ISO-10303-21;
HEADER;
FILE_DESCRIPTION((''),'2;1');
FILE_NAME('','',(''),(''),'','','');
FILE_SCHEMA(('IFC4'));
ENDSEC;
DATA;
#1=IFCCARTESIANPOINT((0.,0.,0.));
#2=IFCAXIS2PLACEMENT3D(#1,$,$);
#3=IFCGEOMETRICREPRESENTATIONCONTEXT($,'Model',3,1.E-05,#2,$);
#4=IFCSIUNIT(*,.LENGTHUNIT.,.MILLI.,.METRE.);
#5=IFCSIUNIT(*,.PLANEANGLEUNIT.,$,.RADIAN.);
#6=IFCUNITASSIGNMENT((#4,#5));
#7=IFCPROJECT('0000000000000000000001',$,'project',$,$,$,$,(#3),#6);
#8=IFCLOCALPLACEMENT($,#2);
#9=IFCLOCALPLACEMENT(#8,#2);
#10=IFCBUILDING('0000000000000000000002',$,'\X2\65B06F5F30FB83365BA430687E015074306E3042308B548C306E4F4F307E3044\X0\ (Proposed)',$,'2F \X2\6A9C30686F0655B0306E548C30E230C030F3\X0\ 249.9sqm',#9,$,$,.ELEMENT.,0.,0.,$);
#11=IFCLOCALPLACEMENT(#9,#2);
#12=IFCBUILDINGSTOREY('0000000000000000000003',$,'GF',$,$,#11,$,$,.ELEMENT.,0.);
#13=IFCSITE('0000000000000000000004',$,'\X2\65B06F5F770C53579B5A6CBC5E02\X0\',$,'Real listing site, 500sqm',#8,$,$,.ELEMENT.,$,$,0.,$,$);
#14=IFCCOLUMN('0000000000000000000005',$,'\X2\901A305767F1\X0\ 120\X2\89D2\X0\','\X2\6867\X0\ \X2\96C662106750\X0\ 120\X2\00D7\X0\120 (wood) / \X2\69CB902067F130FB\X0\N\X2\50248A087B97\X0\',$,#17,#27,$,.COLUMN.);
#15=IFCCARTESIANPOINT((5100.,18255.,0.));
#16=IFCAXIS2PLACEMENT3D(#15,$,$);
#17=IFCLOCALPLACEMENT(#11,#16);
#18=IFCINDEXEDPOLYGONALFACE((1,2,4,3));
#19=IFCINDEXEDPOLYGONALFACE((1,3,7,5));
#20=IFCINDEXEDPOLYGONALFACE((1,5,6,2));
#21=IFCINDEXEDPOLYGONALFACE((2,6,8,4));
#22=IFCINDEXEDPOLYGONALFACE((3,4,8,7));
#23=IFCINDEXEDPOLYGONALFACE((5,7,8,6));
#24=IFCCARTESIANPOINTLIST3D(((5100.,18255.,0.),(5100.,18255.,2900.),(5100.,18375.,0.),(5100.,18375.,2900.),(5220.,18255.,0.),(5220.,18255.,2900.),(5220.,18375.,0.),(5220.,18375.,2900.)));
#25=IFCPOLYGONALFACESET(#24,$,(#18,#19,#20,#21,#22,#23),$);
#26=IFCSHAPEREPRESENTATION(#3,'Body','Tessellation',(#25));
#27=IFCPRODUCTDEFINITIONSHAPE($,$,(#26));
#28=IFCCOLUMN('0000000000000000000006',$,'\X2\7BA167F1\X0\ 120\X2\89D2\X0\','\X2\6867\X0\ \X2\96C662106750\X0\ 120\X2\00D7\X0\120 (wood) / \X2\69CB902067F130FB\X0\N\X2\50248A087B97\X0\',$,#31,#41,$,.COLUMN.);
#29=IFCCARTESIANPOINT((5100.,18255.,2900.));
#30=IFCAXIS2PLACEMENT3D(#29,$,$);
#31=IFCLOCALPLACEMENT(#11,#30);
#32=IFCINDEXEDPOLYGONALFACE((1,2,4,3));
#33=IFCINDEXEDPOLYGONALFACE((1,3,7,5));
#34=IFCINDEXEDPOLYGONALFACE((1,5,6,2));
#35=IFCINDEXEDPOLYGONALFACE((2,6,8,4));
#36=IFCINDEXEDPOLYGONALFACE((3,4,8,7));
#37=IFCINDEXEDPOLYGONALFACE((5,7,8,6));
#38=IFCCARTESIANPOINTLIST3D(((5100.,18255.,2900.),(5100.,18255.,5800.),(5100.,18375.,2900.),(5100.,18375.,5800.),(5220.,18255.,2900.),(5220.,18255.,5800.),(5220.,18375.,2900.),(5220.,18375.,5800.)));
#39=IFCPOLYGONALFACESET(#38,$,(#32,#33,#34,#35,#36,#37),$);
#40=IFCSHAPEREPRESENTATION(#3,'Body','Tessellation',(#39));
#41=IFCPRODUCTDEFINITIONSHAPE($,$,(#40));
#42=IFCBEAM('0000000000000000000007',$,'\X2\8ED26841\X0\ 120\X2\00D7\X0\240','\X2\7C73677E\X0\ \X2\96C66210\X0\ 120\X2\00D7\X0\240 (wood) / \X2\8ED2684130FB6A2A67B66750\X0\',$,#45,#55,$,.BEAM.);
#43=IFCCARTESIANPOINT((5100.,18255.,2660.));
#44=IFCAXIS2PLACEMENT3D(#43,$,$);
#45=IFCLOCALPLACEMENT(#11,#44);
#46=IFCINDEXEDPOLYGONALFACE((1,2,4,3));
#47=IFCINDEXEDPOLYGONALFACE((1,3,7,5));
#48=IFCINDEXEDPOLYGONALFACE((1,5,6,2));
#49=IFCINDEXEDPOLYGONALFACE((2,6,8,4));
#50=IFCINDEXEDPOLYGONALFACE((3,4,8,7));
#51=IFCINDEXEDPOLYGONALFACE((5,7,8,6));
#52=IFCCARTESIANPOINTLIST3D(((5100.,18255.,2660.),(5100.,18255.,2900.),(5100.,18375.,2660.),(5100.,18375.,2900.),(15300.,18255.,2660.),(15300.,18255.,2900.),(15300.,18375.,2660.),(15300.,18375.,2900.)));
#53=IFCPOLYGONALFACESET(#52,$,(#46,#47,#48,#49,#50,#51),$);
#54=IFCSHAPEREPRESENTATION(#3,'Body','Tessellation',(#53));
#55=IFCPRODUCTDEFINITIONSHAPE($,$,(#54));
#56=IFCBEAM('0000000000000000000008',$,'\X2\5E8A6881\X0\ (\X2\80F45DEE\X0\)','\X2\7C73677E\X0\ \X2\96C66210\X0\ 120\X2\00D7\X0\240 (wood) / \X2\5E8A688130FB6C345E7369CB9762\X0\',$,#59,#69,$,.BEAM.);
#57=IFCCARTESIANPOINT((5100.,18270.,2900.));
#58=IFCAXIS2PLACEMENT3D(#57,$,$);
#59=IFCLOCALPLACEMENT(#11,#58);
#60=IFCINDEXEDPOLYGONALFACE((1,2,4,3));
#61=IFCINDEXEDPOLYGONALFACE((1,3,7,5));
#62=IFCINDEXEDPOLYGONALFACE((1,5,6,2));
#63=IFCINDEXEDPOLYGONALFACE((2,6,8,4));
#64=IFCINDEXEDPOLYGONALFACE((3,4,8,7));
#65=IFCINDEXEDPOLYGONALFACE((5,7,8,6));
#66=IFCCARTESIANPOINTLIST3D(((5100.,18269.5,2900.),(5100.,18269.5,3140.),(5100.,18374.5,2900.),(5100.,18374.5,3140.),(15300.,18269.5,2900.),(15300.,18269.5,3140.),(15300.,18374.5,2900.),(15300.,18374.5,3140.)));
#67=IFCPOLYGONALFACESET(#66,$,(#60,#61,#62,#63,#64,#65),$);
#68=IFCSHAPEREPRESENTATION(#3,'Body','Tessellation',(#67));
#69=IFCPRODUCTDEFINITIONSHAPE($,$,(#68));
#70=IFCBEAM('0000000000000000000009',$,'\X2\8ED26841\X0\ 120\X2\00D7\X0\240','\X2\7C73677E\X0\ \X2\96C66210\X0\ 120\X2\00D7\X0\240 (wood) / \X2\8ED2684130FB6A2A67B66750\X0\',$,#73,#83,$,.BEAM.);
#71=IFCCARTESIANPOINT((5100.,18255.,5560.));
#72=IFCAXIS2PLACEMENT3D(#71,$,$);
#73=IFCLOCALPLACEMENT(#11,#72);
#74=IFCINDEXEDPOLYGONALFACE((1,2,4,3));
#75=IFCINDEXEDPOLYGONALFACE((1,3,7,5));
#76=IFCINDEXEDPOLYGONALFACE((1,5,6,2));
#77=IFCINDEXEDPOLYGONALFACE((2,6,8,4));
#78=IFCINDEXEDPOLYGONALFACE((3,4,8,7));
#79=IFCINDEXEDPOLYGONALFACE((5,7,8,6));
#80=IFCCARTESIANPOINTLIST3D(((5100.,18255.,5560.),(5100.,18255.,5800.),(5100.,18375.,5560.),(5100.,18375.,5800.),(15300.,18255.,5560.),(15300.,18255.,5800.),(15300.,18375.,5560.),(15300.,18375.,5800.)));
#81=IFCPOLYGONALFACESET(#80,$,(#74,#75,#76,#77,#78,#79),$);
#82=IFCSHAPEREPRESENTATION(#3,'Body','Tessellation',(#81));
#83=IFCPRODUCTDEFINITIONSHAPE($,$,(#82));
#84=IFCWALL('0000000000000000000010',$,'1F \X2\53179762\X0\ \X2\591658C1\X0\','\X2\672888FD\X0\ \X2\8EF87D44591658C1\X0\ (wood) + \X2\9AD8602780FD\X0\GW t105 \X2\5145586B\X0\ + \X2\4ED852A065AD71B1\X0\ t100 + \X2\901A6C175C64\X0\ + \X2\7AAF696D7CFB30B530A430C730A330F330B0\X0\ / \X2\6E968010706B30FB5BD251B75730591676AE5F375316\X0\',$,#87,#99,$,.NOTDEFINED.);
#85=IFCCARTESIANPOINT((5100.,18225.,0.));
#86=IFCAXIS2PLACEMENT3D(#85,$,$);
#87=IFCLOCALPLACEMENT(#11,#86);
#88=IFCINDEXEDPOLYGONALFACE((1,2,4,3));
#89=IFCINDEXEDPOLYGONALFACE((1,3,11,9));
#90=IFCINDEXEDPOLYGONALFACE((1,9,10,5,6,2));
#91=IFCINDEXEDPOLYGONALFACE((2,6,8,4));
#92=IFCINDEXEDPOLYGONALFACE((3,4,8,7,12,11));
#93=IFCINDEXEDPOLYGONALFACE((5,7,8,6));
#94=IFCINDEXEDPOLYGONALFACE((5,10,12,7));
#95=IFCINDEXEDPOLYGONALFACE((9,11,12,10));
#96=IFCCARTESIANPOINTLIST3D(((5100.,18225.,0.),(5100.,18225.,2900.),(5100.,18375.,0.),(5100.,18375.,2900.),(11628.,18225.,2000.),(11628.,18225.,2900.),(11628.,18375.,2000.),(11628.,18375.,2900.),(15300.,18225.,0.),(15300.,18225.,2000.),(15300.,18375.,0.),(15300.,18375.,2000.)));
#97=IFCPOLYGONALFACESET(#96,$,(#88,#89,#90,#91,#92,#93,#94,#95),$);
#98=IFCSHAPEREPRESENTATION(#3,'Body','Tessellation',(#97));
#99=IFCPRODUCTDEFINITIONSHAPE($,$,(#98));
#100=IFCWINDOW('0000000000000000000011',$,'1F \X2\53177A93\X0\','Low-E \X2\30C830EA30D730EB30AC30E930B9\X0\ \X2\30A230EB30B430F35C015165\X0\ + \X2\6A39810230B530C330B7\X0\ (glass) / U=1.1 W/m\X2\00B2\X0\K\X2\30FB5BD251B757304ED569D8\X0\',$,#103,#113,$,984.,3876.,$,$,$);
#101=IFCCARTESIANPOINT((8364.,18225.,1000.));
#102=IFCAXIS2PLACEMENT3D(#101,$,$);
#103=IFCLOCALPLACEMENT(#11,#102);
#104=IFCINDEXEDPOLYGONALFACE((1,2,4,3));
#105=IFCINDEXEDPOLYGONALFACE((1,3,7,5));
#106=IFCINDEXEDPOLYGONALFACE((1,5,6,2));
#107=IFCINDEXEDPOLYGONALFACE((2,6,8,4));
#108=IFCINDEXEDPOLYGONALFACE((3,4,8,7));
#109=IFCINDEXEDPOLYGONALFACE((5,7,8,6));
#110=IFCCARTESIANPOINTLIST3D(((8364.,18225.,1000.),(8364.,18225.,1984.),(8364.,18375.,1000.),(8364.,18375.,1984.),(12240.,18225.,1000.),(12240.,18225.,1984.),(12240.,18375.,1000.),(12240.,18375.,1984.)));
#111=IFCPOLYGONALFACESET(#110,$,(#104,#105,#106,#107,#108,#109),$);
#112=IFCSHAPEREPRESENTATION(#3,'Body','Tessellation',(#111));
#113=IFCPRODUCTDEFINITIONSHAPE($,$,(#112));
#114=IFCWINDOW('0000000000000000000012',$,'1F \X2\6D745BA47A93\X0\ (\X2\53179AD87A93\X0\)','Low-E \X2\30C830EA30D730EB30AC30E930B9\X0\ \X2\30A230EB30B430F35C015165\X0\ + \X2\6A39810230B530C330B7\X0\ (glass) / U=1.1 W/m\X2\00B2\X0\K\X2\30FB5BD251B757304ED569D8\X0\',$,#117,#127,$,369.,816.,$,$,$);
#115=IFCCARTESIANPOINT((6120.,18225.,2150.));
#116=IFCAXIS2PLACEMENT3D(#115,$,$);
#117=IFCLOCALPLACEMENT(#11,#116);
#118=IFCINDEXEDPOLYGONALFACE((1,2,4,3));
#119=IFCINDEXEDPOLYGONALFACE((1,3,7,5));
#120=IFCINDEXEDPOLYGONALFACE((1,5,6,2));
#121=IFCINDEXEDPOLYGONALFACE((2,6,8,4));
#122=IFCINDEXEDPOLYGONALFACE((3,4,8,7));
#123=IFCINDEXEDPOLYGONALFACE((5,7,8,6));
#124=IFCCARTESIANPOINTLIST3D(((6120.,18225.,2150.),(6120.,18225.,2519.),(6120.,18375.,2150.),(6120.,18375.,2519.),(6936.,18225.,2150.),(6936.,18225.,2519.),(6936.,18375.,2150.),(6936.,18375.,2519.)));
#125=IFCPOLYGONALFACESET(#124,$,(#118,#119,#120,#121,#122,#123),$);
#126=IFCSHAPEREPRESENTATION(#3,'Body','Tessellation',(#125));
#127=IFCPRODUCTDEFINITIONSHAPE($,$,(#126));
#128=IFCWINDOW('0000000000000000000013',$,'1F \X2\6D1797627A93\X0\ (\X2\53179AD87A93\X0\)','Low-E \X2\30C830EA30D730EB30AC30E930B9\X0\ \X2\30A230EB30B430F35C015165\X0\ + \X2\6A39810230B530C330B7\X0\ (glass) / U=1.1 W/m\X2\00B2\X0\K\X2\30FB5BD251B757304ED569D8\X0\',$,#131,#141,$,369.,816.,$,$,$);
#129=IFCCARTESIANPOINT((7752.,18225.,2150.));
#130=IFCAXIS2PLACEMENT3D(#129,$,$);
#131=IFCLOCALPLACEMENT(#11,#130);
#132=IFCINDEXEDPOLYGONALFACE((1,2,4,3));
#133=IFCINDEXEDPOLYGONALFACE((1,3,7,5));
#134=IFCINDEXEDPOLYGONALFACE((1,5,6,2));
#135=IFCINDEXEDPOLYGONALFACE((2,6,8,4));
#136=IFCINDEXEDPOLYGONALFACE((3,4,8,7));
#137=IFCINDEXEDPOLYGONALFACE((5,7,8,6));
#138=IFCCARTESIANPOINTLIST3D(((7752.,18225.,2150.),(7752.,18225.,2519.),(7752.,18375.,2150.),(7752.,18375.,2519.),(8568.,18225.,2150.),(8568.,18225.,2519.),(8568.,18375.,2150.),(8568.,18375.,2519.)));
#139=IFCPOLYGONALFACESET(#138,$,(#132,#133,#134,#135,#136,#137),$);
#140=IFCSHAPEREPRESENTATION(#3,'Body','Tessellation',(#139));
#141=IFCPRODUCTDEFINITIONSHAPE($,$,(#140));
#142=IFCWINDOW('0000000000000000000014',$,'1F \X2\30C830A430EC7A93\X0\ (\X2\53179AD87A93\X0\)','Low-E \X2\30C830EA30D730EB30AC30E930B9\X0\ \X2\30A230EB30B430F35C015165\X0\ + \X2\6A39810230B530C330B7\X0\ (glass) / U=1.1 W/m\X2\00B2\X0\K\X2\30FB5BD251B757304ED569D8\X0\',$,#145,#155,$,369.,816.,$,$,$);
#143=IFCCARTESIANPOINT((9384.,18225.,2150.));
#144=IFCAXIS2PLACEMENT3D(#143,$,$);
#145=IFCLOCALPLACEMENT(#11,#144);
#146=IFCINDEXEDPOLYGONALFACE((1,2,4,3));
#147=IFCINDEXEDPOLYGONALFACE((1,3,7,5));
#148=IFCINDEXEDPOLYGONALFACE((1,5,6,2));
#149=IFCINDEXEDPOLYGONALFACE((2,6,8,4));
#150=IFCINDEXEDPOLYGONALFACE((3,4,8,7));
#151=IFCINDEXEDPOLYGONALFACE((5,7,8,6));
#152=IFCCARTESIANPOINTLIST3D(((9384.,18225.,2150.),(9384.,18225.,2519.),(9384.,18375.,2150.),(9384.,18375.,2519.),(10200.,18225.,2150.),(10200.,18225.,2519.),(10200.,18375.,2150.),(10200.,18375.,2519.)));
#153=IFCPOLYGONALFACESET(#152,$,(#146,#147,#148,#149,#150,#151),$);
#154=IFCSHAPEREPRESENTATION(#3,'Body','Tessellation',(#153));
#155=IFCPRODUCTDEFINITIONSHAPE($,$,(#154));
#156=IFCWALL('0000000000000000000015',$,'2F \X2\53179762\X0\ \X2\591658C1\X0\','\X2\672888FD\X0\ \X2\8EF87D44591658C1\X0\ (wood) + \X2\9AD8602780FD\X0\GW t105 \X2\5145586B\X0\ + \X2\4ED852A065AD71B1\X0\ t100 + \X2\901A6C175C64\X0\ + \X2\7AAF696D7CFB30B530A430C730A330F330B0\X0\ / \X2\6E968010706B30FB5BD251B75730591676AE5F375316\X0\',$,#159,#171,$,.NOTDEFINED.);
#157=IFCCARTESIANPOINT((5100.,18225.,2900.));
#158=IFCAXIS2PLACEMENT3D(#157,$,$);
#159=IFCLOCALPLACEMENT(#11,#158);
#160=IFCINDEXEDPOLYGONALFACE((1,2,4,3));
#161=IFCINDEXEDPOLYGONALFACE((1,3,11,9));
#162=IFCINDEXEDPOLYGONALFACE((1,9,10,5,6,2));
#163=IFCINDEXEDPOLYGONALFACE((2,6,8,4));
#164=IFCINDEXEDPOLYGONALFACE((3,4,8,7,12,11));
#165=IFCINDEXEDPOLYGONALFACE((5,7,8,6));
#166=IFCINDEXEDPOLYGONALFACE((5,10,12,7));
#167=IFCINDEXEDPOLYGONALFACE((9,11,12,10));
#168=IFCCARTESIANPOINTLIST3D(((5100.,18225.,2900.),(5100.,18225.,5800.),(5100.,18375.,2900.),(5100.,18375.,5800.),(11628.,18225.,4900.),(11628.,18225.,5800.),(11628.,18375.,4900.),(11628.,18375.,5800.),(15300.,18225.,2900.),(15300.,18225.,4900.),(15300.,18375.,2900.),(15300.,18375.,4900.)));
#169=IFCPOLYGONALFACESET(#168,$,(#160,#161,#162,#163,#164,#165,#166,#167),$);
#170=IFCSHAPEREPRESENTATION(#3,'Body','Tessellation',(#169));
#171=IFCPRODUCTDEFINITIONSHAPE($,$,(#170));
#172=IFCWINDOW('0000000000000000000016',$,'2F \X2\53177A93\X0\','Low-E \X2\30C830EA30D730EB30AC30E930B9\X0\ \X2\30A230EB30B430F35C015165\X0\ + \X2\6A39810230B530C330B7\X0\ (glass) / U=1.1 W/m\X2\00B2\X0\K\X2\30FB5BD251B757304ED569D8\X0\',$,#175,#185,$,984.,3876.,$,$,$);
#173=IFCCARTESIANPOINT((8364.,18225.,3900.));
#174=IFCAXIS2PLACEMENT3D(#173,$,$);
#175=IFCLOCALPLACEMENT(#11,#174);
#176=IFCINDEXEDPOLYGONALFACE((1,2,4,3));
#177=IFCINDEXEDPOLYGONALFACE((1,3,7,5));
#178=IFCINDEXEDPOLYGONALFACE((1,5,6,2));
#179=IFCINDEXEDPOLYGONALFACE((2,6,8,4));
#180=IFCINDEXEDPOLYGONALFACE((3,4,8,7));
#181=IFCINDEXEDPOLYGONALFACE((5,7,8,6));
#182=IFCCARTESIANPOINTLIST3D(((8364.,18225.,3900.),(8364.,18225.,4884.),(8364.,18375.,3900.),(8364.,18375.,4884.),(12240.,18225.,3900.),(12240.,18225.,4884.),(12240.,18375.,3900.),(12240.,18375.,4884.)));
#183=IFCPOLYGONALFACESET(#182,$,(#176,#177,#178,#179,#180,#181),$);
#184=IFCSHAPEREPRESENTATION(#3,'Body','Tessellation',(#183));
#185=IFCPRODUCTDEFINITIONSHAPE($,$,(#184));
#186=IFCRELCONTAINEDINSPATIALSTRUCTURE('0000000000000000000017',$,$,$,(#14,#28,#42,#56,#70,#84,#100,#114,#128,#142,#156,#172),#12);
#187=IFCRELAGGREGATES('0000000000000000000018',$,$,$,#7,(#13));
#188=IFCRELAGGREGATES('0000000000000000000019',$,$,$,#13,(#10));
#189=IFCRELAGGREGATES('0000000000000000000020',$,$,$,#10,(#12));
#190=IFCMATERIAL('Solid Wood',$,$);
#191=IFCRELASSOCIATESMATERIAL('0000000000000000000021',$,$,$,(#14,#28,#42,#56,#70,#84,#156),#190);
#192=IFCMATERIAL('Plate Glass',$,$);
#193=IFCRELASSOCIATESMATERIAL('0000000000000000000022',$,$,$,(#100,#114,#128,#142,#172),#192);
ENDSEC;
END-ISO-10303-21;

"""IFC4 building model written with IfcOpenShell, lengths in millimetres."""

from ifc_helpers import new_model, si_unit, frame, frame_2d, origin, place, context, project, spatial, rectangle, extrude, material, element, fill, save


model = new_model("IFC4")

# Units and contexts
model_context = context("Model", 3, precision=1e-05, world=origin())
ifc_project = project(units=[si_unit("LENGTHUNIT", "METRE", prefix="MILLI"), si_unit("PLANEANGLEUNIT", "RADIAN")], contexts=[model_context])

# Site, building, storey
site_placement = place(None, origin())
site = spatial("IfcSite", under=ifc_project, at=site_placement, Name="新潟県南魚沼市", ObjectType="Real listing site, 500sqm", CompositionType="ELEMENT", RefElevation=0.0)
building_placement = place(site_placement, origin())
building = spatial("IfcBuilding", under=site, at=building_placement, Name="新潟・茶室と縁側のある和の住まい (Proposed)", ObjectType="2F 檜と漆喰の和モダン 249.9sqm", CompositionType="ELEMENT", ElevationOfRefHeight=0.0, ElevationOfTerrain=0.0)
storey_placement = place(building_placement, origin())
storey = spatial("IfcBuildingStorey", under=building, at=storey_placement, Name="GF", CompositionType="ELEMENT", Elevation=0.0)

# Columns
ifc_material_1 = material(Name="Solid Wood")
column_1_placement = place(storey_placement, frame((5100.0, 18255.0, 0.0)))
element("IfcColumn", 1, at=column_1_placement, inside=storey, material=ifc_material_1, Name="通し柱 120角", Description="桧 集成材 120×120 (wood) / 構造柱・N値計算", PredefinedType="COLUMN", context=model_context, shape_type="SweptSolid", body=[
    extrude(rectangle(XDim=120.0, YDim=120.0, at=frame_2d((60.0, 60.0))), frame((5100.0, 18255.0, 0.0)), (0.0, 0.0, 1.0), 2900.0),
])
column_2_placement = place(storey_placement, frame((5100.0, 18255.0, 2900.0)))
element("IfcColumn", 2, at=column_2_placement, inside=storey, material=ifc_material_1, Name="管柱 120角", Description="桧 集成材 120×120 (wood) / 構造柱・N値計算", PredefinedType="COLUMN", context=model_context, shape_type="SweptSolid", body=[
    extrude(rectangle(XDim=120.0, YDim=120.0, at=frame_2d((60.0, 60.0))), frame((5100.0, 18255.0, 2900.0)), (0.0, 0.0, 1.0), 2900.0),
])

# Beams
beam_1_placement = place(storey_placement, frame((5100.0, 18255.0, 2660.0)))
element("IfcBeam", 3, at=beam_1_placement, inside=storey, material=ifc_material_1, Name="軒桁 120×240", Description="米松 集成 120×240 (wood) / 軒桁・横架材", PredefinedType="BEAM", context=model_context, shape_type="SweptSolid", body=[
    extrude(rectangle(XDim=10200.0, YDim=120.0, at=frame_2d((5100.0, 60.0))), frame((5100.0, 18255.0, 2660.0)), (0.0, 0.0, 1.0), 240.0),
])
beam_2_placement = place(storey_placement, frame((5100.0, 18270.0, 2900.0)))
element("IfcBeam", 4, at=beam_2_placement, inside=storey, material=ifc_material_1, Name="床梁 (胴差)", Description="米松 集成 120×240 (wood) / 床梁・水平構面", PredefinedType="BEAM", context=model_context, shape_type="SweptSolid", body=[
    extrude(rectangle(XDim=10200.0, YDim=105.0, at=frame_2d((5100.0, 52.0))), frame((5100.0, 18270.0, 2900.0)), (0.0, 0.0, 1.0), 240.0),
])
beam_3_placement = place(storey_placement, frame((5100.0, 18255.0, 5560.0)))
element("IfcBeam", 5, at=beam_3_placement, inside=storey, material=ifc_material_1, Name="軒桁 120×240", Description="米松 集成 120×240 (wood) / 軒桁・横架材", PredefinedType="BEAM", context=model_context, shape_type="SweptSolid", body=[
    extrude(rectangle(XDim=10200.0, YDim=120.0, at=frame_2d((5100.0, 60.0))), frame((5100.0, 18255.0, 5560.0)), (0.0, 0.0, 1.0), 240.0),
])

# Wall, openings, windows
wall_1_placement = place(storey_placement, frame((5100.0, 18225.0, 0.0)))
wall_1 = element("IfcWall", 6, at=wall_1_placement, inside=storey, material=ifc_material_1, Name="1F 北面 外壁", Description="木製 軸組外壁 (wood) + 高性能GW t105 充填 + 付加断熱 t100 + 通気層 + 窯業系サイディング / 準耐火・寒冷地外皮強化", PredefinedType="NOTDEFINED", context=model_context, shape_type="SweptSolid", body=[
    extrude(rectangle(XDim=10200.0, YDim=150.0, at=frame_2d((5100.0, 75.0))), frame((5100.0, 18225.0, 0.0)), (0.0, 0.0, 1.0), 2900.0),
])
opening_1_placement = place(storey_placement, frame((8364.0, 18225.0, 1000.0)))
opening_1 = element("IfcOpeningElement", 7, at=opening_1_placement, cuts=wall_1, PredefinedType="NOTDEFINED", context=model_context, shape_type="SweptSolid", body=[
    extrude(rectangle(XDim=3876.0, YDim=150.0, at=frame_2d((1938.0, 75.0))), frame((8364.0, 18225.0, 1000.0)), (0.0, 0.0, 1.0), 984.0),
])
opening_2_placement = place(storey_placement, frame((6120.0, 18225.0, 2150.0)))
opening_2 = element("IfcOpeningElement", 8, at=opening_2_placement, cuts=wall_1, PredefinedType="NOTDEFINED", context=model_context, shape_type="SweptSolid", body=[
    extrude(rectangle(XDim=816.0, YDim=150.0, at=frame_2d((408.0, 75.0))), frame((6120.0, 18225.0, 2150.0)), (0.0, 0.0, 1.0), 369.0),
])
opening_3_placement = place(storey_placement, frame((7752.0, 18225.0, 2150.0)))
opening_3 = element("IfcOpeningElement", 9, at=opening_3_placement, cuts=wall_1, PredefinedType="NOTDEFINED", context=model_context, shape_type="SweptSolid", body=[
    extrude(rectangle(XDim=816.0, YDim=150.0, at=frame_2d((408.0, 75.0))), frame((7752.0, 18225.0, 2150.0)), (0.0, 0.0, 1.0), 369.0),
])
opening_4_placement = place(storey_placement, frame((9384.0, 18225.0, 2150.0)))
opening_4 = element("IfcOpeningElement", 10, at=opening_4_placement, cuts=wall_1, PredefinedType="NOTDEFINED", context=model_context, shape_type="SweptSolid", body=[
    extrude(rectangle(XDim=816.0, YDim=150.0, at=frame_2d((408.0, 75.0))), frame((9384.0, 18225.0, 2150.0)), (0.0, 0.0, 1.0), 369.0),
])
ifc_material_2 = material(Name="Plate Glass")
window_1_placement = place(storey_placement, frame((8364.0, 18225.0, 1000.0)))
window_1 = element("IfcWindow", 11, at=window_1_placement, inside=storey, material=ifc_material_2, Name="1F 北窓", Description="Low-E トリプルガラス アルゴン封入 + 樹脂サッシ (glass) / U=1.1 W/m²K・寒冷地仕様", OverallHeight=984.0, OverallWidth=3876.0, context=model_context, shape_type="SweptSolid", body=[
    extrude(rectangle(XDim=3876.0, YDim=150.0, at=frame_2d((1938.0, 75.0))), frame((8364.0, 18225.0, 1000.0)), (0.0, 0.0, 1.0), 984.0),
])
fill(opening_1, window_1)
window_2_placement = place(storey_placement, frame((6120.0, 18225.0, 2150.0)))
window_2 = element("IfcWindow", 12, at=window_2_placement, inside=storey, material=ifc_material_2, Name="1F 浴室窓 (北高窓)", Description="Low-E トリプルガラス アルゴン封入 + 樹脂サッシ (glass) / U=1.1 W/m²K・寒冷地仕様", OverallHeight=369.0, OverallWidth=816.0, context=model_context, shape_type="SweptSolid", body=[
    extrude(rectangle(XDim=816.0, YDim=150.0, at=frame_2d((408.0, 75.0))), frame((6120.0, 18225.0, 2150.0)), (0.0, 0.0, 1.0), 369.0),
])
fill(opening_2, window_2)
window_3_placement = place(storey_placement, frame((7752.0, 18225.0, 2150.0)))
window_3 = element("IfcWindow", 13, at=window_3_placement, inside=storey, material=ifc_material_2, Name="1F 洗面窓 (北高窓)", Description="Low-E トリプルガラス アルゴン封入 + 樹脂サッシ (glass) / U=1.1 W/m²K・寒冷地仕様", OverallHeight=369.0, OverallWidth=816.0, context=model_context, shape_type="SweptSolid", body=[
    extrude(rectangle(XDim=816.0, YDim=150.0, at=frame_2d((408.0, 75.0))), frame((7752.0, 18225.0, 2150.0)), (0.0, 0.0, 1.0), 369.0),
])
fill(opening_3, window_3)
window_4_placement = place(storey_placement, frame((9384.0, 18225.0, 2150.0)))
window_4 = element("IfcWindow", 14, at=window_4_placement, inside=storey, material=ifc_material_2, Name="1F トイレ窓 (北高窓)", Description="Low-E トリプルガラス アルゴン封入 + 樹脂サッシ (glass) / U=1.1 W/m²K・寒冷地仕様", OverallHeight=369.0, OverallWidth=816.0, context=model_context, shape_type="SweptSolid", body=[
    extrude(rectangle(XDim=816.0, YDim=150.0, at=frame_2d((408.0, 75.0))), frame((9384.0, 18225.0, 2150.0)), (0.0, 0.0, 1.0), 369.0),
])
fill(opening_4, window_4)

# Wall, opening, window
wall_2_placement = place(storey_placement, frame((5100.0, 18225.0, 2900.0)))
wall_2 = element("IfcWall", 15, at=wall_2_placement, inside=storey, material=ifc_material_1, Name="2F 北面 外壁", Description="木製 軸組外壁 (wood) + 高性能GW t105 充填 + 付加断熱 t100 + 通気層 + 窯業系サイディング / 準耐火・寒冷地外皮強化", PredefinedType="NOTDEFINED", context=model_context, shape_type="SweptSolid", body=[
    extrude(rectangle(XDim=10200.0, YDim=150.0, at=frame_2d((5100.0, 75.0))), frame((5100.0, 18225.0, 2900.0)), (0.0, 0.0, 1.0), 2900.0),
])
opening_5_placement = place(storey_placement, frame((8364.0, 18225.0, 3900.0)))
opening_5 = element("IfcOpeningElement", 16, at=opening_5_placement, cuts=wall_2, PredefinedType="NOTDEFINED", context=model_context, shape_type="SweptSolid", body=[
    extrude(rectangle(XDim=3876.0, YDim=150.0, at=frame_2d((1938.0, 75.0))), frame((8364.0, 18225.0, 3900.0)), (0.0, 0.0, 1.0), 984.0),
])
window_5_placement = place(storey_placement, frame((8364.0, 18225.0, 3900.0)))
window_5 = element("IfcWindow", 17, at=window_5_placement, inside=storey, material=ifc_material_2, Name="2F 北窓", Description="Low-E トリプルガラス アルゴン封入 + 樹脂サッシ (glass) / U=1.1 W/m²K・寒冷地仕様", OverallHeight=984.0, OverallWidth=3876.0, context=model_context, shape_type="SweptSolid", body=[
    extrude(rectangle(XDim=3876.0, YDim=150.0, at=frame_2d((1938.0, 75.0))), frame((8364.0, 18225.0, 3900.0)), (0.0, 0.0, 1.0), 984.0),
])
fill(opening_5, window_5)

save(model, "model.ifc")
